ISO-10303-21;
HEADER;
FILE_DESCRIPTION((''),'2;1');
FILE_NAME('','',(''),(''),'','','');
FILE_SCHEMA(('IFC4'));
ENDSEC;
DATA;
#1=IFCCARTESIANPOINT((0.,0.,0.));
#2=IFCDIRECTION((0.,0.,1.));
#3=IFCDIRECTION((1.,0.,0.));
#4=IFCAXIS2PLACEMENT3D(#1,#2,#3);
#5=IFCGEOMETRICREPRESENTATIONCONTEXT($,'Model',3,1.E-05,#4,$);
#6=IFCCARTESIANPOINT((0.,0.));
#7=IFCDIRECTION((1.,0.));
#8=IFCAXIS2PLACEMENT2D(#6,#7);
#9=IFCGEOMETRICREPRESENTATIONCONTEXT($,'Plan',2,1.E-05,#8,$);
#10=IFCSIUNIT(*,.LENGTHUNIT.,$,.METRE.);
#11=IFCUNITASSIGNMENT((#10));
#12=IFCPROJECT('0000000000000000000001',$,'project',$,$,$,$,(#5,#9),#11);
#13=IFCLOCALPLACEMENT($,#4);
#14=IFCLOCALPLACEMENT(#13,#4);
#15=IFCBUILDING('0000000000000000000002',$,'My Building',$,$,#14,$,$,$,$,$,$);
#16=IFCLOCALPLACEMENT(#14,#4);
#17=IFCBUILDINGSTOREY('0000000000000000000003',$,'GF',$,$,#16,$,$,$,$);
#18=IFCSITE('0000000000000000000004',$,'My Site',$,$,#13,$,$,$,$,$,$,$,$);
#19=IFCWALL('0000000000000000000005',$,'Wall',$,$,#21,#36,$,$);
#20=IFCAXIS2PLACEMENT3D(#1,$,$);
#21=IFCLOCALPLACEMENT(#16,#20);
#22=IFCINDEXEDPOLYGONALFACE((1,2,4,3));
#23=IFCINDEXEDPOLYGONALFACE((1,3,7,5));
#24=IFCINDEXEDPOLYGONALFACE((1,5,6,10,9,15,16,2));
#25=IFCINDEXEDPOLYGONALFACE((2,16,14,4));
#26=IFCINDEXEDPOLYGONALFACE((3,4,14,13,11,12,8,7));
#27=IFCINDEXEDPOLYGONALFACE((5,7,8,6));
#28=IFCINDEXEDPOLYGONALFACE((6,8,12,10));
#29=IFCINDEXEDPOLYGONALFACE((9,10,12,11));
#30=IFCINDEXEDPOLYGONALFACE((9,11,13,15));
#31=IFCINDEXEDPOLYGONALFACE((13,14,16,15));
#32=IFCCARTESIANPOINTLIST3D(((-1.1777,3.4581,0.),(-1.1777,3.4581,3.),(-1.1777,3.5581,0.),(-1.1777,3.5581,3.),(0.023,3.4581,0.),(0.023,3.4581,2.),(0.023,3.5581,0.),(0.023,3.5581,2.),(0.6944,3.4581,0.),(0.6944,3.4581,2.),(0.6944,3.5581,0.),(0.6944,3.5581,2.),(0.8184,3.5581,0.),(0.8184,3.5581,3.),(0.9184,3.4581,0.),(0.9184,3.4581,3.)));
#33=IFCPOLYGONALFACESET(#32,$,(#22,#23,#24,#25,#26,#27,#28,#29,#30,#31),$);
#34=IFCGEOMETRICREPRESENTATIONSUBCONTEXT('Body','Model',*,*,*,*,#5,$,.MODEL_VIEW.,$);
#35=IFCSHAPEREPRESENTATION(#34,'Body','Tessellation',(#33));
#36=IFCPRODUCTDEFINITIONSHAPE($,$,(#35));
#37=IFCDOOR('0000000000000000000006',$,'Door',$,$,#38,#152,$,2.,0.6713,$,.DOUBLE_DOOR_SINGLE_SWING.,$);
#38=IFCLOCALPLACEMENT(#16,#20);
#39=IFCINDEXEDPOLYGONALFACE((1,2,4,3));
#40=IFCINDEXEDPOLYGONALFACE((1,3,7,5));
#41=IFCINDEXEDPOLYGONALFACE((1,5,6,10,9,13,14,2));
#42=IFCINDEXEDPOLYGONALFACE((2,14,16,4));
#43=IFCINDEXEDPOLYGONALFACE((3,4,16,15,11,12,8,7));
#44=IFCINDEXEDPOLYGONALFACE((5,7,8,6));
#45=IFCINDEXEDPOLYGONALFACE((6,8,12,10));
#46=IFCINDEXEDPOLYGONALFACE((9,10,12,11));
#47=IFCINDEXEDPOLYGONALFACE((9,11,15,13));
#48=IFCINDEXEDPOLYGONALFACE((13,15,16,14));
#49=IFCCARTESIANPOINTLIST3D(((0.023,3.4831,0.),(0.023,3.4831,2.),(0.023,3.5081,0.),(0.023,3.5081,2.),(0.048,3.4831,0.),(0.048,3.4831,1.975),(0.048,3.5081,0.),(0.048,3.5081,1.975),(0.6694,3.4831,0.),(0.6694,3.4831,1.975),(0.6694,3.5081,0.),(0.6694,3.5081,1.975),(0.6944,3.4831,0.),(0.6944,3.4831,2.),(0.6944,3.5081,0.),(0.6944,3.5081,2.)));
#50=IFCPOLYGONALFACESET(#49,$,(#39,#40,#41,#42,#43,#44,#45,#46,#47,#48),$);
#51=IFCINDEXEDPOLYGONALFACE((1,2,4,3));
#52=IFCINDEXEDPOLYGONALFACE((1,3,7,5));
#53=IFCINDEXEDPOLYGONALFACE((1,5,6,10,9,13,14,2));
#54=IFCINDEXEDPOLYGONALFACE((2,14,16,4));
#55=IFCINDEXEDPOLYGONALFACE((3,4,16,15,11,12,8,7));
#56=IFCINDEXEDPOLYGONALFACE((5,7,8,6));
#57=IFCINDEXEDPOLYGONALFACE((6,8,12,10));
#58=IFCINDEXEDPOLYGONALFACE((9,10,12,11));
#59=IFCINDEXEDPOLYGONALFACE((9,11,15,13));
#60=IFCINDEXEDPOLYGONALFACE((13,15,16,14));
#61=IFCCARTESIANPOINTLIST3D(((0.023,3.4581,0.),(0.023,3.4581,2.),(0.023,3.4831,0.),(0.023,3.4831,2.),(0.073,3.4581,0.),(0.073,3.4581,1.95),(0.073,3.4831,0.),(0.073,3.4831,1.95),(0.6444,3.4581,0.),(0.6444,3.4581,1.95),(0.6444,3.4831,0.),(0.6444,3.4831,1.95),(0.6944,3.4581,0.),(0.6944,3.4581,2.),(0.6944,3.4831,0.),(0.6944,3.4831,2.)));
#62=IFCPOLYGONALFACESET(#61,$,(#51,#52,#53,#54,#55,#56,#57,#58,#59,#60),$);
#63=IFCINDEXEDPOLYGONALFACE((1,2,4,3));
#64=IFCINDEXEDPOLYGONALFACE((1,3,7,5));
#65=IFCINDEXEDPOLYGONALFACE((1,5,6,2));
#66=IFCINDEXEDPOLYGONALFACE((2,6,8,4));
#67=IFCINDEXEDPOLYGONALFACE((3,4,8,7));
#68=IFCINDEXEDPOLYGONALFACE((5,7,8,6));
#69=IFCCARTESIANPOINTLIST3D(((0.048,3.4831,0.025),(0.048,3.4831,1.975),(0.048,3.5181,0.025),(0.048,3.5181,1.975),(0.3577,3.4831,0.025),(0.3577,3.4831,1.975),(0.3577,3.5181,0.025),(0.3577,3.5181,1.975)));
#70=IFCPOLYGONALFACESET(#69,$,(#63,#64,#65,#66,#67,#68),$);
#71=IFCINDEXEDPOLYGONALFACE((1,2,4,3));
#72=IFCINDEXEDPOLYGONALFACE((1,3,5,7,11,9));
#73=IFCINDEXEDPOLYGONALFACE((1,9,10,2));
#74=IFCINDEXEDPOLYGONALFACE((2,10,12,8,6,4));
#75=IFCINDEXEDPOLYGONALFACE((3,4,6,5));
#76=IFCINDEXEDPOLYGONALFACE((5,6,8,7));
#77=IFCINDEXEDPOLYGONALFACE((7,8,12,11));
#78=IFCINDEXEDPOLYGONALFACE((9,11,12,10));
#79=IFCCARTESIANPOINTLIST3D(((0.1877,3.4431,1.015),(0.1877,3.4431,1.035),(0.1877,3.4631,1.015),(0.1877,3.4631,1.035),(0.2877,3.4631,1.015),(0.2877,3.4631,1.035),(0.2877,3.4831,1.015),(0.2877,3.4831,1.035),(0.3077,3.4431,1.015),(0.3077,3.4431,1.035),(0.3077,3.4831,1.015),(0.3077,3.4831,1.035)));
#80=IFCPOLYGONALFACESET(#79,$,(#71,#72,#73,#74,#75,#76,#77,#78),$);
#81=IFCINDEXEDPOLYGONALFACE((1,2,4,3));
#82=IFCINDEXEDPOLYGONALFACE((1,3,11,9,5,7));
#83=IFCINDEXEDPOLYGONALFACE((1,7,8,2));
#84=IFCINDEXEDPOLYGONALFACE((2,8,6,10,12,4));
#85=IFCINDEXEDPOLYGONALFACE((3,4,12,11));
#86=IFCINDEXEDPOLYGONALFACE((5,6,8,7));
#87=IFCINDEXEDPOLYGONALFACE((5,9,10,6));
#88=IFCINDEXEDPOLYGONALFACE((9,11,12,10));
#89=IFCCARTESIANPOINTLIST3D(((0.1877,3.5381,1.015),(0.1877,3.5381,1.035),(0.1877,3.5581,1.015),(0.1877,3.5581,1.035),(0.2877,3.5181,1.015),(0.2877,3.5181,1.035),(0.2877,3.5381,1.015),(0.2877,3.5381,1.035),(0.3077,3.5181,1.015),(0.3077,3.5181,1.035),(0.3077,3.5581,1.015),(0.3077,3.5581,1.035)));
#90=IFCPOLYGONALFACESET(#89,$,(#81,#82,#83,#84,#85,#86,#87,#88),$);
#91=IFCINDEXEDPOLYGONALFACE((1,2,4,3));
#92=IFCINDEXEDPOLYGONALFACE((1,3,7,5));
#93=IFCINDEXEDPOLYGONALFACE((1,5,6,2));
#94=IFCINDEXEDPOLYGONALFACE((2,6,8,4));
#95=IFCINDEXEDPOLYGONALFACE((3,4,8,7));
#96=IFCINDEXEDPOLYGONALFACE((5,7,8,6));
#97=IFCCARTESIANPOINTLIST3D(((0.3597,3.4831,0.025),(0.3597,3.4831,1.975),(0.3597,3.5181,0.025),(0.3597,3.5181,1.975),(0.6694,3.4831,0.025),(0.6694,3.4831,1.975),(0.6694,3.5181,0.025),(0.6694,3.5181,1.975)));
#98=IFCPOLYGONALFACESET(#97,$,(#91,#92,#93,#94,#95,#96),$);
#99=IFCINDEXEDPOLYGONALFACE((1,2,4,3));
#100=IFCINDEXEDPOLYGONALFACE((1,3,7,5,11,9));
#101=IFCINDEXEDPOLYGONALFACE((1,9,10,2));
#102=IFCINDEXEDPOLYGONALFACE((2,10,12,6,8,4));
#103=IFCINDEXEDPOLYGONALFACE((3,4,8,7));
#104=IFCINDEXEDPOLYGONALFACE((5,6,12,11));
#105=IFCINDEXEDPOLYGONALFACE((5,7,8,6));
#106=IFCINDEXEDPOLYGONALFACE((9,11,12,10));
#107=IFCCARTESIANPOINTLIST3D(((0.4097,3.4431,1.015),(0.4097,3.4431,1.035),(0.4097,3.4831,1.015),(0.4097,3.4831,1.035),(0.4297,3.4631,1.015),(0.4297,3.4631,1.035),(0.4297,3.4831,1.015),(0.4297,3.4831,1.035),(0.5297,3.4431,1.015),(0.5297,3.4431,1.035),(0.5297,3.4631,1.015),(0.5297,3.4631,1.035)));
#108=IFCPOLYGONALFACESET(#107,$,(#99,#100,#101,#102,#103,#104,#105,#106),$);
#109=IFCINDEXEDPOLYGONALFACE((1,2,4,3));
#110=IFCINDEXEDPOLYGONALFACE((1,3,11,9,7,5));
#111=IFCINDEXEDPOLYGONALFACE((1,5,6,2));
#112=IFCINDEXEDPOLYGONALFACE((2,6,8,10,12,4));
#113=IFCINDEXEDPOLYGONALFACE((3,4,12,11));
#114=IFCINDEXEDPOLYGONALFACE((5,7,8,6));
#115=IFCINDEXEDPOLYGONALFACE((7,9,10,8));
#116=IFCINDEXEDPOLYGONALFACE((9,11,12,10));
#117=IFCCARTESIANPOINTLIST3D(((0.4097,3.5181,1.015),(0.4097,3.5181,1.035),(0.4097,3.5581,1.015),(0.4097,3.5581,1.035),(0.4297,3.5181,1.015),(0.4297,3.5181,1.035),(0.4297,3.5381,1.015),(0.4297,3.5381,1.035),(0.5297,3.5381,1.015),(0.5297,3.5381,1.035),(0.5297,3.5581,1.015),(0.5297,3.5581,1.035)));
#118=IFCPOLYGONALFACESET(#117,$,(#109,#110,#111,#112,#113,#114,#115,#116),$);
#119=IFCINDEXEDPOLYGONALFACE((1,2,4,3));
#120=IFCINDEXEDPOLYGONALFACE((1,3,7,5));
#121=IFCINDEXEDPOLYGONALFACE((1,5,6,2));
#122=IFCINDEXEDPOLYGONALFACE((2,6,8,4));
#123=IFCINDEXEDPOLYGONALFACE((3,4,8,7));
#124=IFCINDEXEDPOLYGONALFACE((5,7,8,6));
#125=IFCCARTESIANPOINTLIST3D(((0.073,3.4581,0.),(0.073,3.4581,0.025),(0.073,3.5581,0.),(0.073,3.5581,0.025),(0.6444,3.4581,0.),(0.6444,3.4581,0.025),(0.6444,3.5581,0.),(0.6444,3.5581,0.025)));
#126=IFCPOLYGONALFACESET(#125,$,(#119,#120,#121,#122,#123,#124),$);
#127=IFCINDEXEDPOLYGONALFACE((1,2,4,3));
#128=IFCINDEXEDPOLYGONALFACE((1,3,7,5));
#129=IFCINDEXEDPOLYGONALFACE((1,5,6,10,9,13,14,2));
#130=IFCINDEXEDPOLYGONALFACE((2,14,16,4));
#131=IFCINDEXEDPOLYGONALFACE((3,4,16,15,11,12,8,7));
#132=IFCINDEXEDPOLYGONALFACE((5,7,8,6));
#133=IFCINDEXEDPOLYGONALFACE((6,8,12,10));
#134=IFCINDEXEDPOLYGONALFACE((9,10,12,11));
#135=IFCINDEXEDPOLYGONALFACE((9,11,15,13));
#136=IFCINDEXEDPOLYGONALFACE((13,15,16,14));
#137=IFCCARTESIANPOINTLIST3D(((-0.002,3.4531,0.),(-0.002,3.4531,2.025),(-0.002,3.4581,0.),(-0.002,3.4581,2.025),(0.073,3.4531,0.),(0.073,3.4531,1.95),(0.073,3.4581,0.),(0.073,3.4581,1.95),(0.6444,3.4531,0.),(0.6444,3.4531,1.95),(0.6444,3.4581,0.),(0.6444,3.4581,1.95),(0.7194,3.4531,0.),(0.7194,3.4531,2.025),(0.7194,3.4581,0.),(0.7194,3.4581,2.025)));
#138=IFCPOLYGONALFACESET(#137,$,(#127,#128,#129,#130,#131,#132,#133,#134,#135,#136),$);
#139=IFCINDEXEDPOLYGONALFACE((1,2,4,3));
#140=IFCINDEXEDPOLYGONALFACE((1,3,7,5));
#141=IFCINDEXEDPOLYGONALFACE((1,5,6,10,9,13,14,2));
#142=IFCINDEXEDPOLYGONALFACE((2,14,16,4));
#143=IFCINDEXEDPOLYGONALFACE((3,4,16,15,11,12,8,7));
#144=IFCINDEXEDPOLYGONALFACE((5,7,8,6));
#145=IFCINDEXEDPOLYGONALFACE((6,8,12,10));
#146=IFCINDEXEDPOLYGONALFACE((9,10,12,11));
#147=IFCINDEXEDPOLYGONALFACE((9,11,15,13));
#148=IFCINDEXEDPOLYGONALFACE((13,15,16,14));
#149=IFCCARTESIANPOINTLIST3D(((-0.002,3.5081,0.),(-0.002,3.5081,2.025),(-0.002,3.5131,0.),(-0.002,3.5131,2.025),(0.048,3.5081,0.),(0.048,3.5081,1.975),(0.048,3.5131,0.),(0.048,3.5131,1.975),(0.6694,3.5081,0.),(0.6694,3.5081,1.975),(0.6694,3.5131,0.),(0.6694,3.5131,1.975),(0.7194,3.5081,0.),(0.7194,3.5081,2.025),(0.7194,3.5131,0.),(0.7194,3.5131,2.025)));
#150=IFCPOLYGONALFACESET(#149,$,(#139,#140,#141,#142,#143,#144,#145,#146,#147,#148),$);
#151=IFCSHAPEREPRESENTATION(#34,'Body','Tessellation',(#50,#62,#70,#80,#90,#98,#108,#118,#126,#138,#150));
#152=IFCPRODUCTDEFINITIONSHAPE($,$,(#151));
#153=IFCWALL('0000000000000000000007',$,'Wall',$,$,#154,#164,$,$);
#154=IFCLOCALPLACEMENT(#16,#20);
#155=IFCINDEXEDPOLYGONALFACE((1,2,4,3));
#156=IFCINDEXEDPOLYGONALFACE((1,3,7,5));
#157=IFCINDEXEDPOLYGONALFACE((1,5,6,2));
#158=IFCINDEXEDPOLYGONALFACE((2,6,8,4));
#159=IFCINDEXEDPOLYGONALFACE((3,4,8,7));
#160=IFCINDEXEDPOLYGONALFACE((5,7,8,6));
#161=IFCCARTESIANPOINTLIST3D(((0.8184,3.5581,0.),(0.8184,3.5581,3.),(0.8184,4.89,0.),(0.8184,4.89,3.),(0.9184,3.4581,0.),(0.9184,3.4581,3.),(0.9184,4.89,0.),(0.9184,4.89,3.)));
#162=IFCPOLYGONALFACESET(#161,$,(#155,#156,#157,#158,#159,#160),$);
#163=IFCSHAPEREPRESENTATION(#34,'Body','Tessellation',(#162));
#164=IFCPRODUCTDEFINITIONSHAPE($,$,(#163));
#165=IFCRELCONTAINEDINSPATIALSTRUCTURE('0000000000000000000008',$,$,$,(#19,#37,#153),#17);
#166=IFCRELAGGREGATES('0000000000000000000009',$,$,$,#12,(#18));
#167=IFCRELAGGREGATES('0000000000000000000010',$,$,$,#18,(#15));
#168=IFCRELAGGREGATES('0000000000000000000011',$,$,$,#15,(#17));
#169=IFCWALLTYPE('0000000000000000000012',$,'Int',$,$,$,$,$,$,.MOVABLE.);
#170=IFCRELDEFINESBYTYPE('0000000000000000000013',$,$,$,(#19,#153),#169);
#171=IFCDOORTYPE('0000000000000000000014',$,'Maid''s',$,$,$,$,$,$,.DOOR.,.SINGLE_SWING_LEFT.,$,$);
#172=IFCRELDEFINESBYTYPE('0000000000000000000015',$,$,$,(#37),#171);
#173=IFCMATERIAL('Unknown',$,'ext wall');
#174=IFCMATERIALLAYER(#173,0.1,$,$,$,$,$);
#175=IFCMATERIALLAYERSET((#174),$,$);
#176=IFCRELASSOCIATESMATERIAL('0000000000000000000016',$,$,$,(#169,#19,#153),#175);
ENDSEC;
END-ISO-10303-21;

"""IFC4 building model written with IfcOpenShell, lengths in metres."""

from ifc_helpers import new_model, entity, si_unit, frame, origin_with_axes, origin_2d_with_axis, place, context, subcontext, project, spatial, line, indexed_curve, outline, extrude, shape, source, transform, mapped, material, layer, layer_set, layer_usage, type_object, type_shapes, element, fill, save


model = new_model("IFC4")

# Units and contexts
model_context = context("Model", 3, precision=1e-05, world=origin_with_axes())
plan_context = context("Plan", 2, precision=1e-05, world=origin_2d_with_axis())
body_context_1 = subcontext(model_context, "Body", "Model", "MODEL_VIEW")
body_context_2 = subcontext(plan_context, "Body", "Plan", "PLAN_VIEW")
ifc_project = project(units=[si_unit("LENGTHUNIT", "METRE")], contexts=[model_context, plan_context])

# Site, building, storey
site_placement = place(None, origin_with_axes())
site = spatial("IfcSite", under=ifc_project, at=site_placement, Name="My Site")
building_placement = place(site_placement, origin_with_axes())
building = spatial("IfcBuilding", under=site, at=building_placement, Name="My Building")
storey_placement = place(building_placement, origin_with_axes())
storey = spatial("IfcBuildingStorey", under=building, at=storey_placement, Name="GF")

# Shared definitions
ifc_material = material(Name="Unknown", Category="ext wall")

# Wall, opening, door
ifc_layer_1 = layer(ifc_material, 0.1)
ifc_layer_set_1 = layer_set([ifc_layer_1])
wall_type_1 = type_object("IfcWallType", Name="Int", PredefinedType="MOVABLE", material=ifc_layer_set_1)
ifc_layer_usage_1 = layer_usage(ifc_layer_set_1, "AXIS2", "POSITIVE", 0.0)
wall_1_placement = place(storey_placement, frame((-1.1777, 3.4581, 0.0), z_axis=(0.0, 0.0, 1.0), x_axis=(1.0, 0.0, 0.0)))
wall_1 = element("IfcWall", 1, at=wall_1_placement, inside=storey, type_object=wall_type_1, material=ifc_layer_usage_1, Name="Wall", context=body_context_1, shape_type="SweptSolid", body=[
    extrude(outline(indexed_curve([(0.0, 0.0), (0.0, 0.1), (1.9961, 0.1), (2.0961, 0.0)], segments=[line(1, 2, 3, 4, 1)])), origin_with_axes(), (0.0, 0.0, 1.0), 3.0),
])
shared_shape_1 = source(origin_with_axes(), body_context_1, "Body", "SweptSolid", [
    extrude(outline(indexed_curve([(0.0, 0.0), (0.6713, 0.0), (0.6713, 2.0), (0.0, 2.0)], segments=[line(1, 2, 3, 4, 1)])), frame((0.0, -0.6, 0.0), z_axis=(0.0, -1.0, 0.0), x_axis=(1.0, 0.0, 0.0)), (0.0, 0.0, -1.0), 1.2),
])
opening_1_placement = place(wall_1_placement, frame((1.2007, 0.0, 0.0), z_axis=(0.0, 0.0, 1.0), x_axis=(1.0, 0.0, 0.0)))
opening_1 = element("IfcOpeningElement", 2, at=opening_1_placement, cuts=wall_1, PredefinedType="OPENING", context=body_context_1, shape_type="MappedRepresentation", body=[
    mapped(shared_shape_1, transform((0.0, 0.0, 0.0), x_axis=(1.0, 0.0, 0.0), y_axis=(0.0, 1.0, 0.0), z_axis=(0.0, 0.0, 1.0), scale=1.0)),
])
door_type_1 = type_object("IfcDoorType", Name="Maid's", OperationType="SINGLE_SWING_LEFT", PredefinedType="DOOR")
shared_shape_2 = source(origin_with_axes(), body_context_1, "Body", "SweptSolid", [
    extrude(outline(indexed_curve([(0.0, 0.0), (0.0, 2.0), (0.6713, 2.0), (0.6713, 0.0), (0.6463, 0.0), (0.6463, 1.975), (0.025, 1.975), (0.025, 0.0)], segments=[line(1, 2, 3, 4, 5, 6, 7, 8, 1)])), frame((0.0, 0.025, 0.0), z_axis=(0.0, -1.0, 0.0), x_axis=(1.0, 0.0, 0.0)), (0.0, 0.0, -1.0), 0.025),
    extrude(outline(indexed_curve([(0.0, 0.0), (0.0, 2.0), (0.6713, 2.0), (0.6713, 0.0), (0.6213, 0.0), (0.6213, 1.95), (0.05, 1.95), (0.05, 0.0)], segments=[line(1, 2, 3, 4, 5, 6, 7, 8, 1)])), frame((0.0, 0.0, 0.0), z_axis=(0.0, -1.0, 0.0), x_axis=(1.0, 0.0, 0.0)), (0.0, 0.0, -1.0), 0.025),
    extrude(outline(indexed_curve([(0.0, 0.0), (0.3097, 0.0), (0.3097, 0.035), (0.0, 0.035)], segments=[line(1, 2, 3, 4, 1)])), frame((0.025, 0.025, 0.025), z_axis=(0.0, 0.0, 1.0), x_axis=(1.0, 0.0, 0.0)), (0.0, 0.0, 1.0), 1.95),
    extrude(outline(indexed_curve([(0.0, 0.0), (0.0, -0.04), (-0.12, -0.04), (-0.12, -0.02), (-0.02, -0.02), (-0.02, 0.0)], segments=[line(1, 2, 3, 4, 5, 6, 1)])), frame((0.2847, 0.025, 1.015), z_axis=(0.0, 0.0, 1.0), x_axis=(1.0, 0.0, 0.0)), (0.0, 0.0, 1.0), 0.02),
    extrude(outline(indexed_curve([(0.0, 0.0), (0.0, 0.04), (-0.12, 0.04), (-0.12, 0.02), (-0.02, 0.02), (-0.02, 0.0)], segments=[line(1, 2, 3, 4, 5, 6, 1)])), frame((0.2847, 0.06, 1.015), z_axis=(0.0, 0.0, 1.0), x_axis=(1.0, 0.0, 0.0)), (0.0, 0.0, 1.0), 0.02),
    extrude(outline(indexed_curve([(0.0, 0.0), (-0.3097, 0.0), (-0.3097, 0.035), (0.0, 0.035)], segments=[line(1, 2, 3, 4, 1)])), frame((0.6463, 0.025, 0.025), z_axis=(0.0, 0.0, 1.0), x_axis=(1.0, 0.0, 0.0)), (0.0, 0.0, 1.0), 1.95),
    extrude(outline(indexed_curve([(0.0, 0.0), (0.0, -0.04), (0.12, -0.04), (0.12, -0.02), (0.02, -0.02), (0.02, 0.0)], segments=[line(1, 2, 3, 4, 5, 6, 1)])), frame((0.3867, 0.025, 1.015), z_axis=(0.0, 0.0, 1.0), x_axis=(1.0, 0.0, 0.0)), (0.0, 0.0, 1.0), 0.02),
    extrude(outline(indexed_curve([(0.0, 0.0), (0.0, 0.04), (0.12, 0.04), (0.12, 0.02), (0.02, 0.02), (0.02, 0.0)], segments=[line(1, 2, 3, 4, 5, 6, 1)])), frame((0.3867, 0.06, 1.015), z_axis=(0.0, 0.0, 1.0), x_axis=(1.0, 0.0, 0.0)), (0.0, 0.0, 1.0), 0.02),
    extrude(outline(indexed_curve([(0.0, 0.0), (0.5713, 0.0), (0.5713, 0.1), (0.0, 0.1)], segments=[line(1, 2, 3, 4, 1)])), frame((0.05, 0.0, 0.0), z_axis=(0.0, 0.0, 1.0), x_axis=(1.0, 0.0, 0.0)), (0.0, 0.0, 1.0), 0.025),
    extrude(outline(indexed_curve([(0.0, 0.0), (0.0, 2.025), (0.7213, 2.025), (0.7213, 0.0), (0.6463, 0.0), (0.6463, 1.95), (0.075, 1.95), (0.075, 0.0)], segments=[line(1, 2, 3, 4, 5, 6, 7, 8, 1)])), frame((-0.025, -0.005, 0.0), z_axis=(0.0, -1.0, 0.0), x_axis=(1.0, 0.0, 0.0)), (0.0, 0.0, -1.0), 0.005),
    extrude(outline(indexed_curve([(0.0, 0.0), (0.0, 2.025), (0.7213, 2.025), (0.7213, 0.0), (0.6713, 0.0), (0.6713, 1.975), (0.05, 1.975), (0.05, 0.0)], segments=[line(1, 2, 3, 4, 5, 6, 7, 8, 1)])), frame((-0.025, 0.05, 0.0), z_axis=(0.0, -1.0, 0.0), x_axis=(1.0, 0.0, 0.0)), (0.0, 0.0, -1.0), 0.005),
])
shared_shape_3 = source(origin_with_axes(), body_context_2, "Body", "Curve2D", [
    entity("IfcIndexedPolyCurve", entity("IfcCartesianPointList2D", [[0.0, 0.0], [0.0, 0.05], [0.025, 0.05], [0.025, 0.025], [0.05, 0.025], [0.05, 0.0]]), [entity("IfcLineIndex", [1, 2, 3, 4, 5, 6, 1])]),
    entity("IfcIndexedPolyCurve", entity("IfcCartesianPointList2D", [[0.6713, 0.0], [0.6713, 0.05], [0.6463, 0.05], [0.6463, 0.025], [0.6213, 0.025], [0.6213, 0.0]]), [entity("IfcLineIndex", [1, 2, 3, 4, 5, 6, 1])]),
    entity("IfcTrimmedCurve", entity("IfcEllipse", entity("IfcAxis2Placement2D", entity("IfcCartesianPoint", [0.06, 0.05]), entity("IfcDirection", [1.0, 0.0])), 0.2757, 0.3107), [entity("IfcCartesianPoint", [0.3357, 0.05])], [entity("IfcCartesianPoint", [0.06, 0.3607])], True, "CARTESIAN"),
    entity("IfcIndexedPolyCurve", entity("IfcCartesianPointList2D", [[0.025, 0.05], [0.06, 0.05], [0.06, 0.3607], [0.025, 0.3607]]), [entity("IfcLineIndex", [1, 2, 3, 4, 1])]),
    entity("IfcTrimmedCurve", entity("IfcEllipse", entity("IfcAxis2Placement2D", entity("IfcCartesianPoint", [0.6113, 0.05]), entity("IfcDirection", [1.0, 0.0])), 0.2757, 0.3107), [entity("IfcCartesianPoint", [0.6113, 0.3607])], [entity("IfcCartesianPoint", [0.3357, 0.05])], True, "CARTESIAN"),
    entity("IfcIndexedPolyCurve", entity("IfcCartesianPointList2D", [[0.6463, 0.05], [0.6113, 0.05], [0.6113, 0.3607], [0.6463, 0.3607]]), [entity("IfcLineIndex", [1, 2, 3, 4, 1])]),
])
type_shapes(door_type_1, [shared_shape_2, shared_shape_3])
door_1_placement = place(opening_1_placement, origin_with_axes())
door_1 = element("IfcDoor", 3, at=door_1_placement, inside=storey, type_object=door_type_1, Name="Door", OperationType="DOUBLE_DOOR_SINGLE_SWING", OverallHeight=2.0, OverallWidth=0.6713, shapes=[
    shape(body_context_1, "Body", "MappedRepresentation", [mapped(shared_shape_2, transform((0.0, 0.0, 0.0), x_axis=(1.0, 0.0, 0.0), y_axis=(0.0, 1.0, 0.0), z_axis=(0.0, 0.0, 1.0), scale=1.0))]),
    shape(body_context_2, "Body", "MappedRepresentation", [mapped(shared_shape_3, transform((0.0, 0.0, 0.0), x_axis=(1.0, 0.0, 0.0), y_axis=(0.0, 1.0, 0.0), z_axis=(0.0, 0.0, 1.0), scale=1.0))]),
])
fill(opening_1, door_1)

# Wall
ifc_layer_usage_2 = layer_usage(ifc_layer_set_1, "AXIS2", "POSITIVE", 0.0)
wall_2_placement = place(storey_placement, frame((0.9184, 3.4581, 0.0), z_axis=(0.0, 0.0, 1.0), x_axis=(0.0, 1.0, 0.0)))
element("IfcWall", 4, at=wall_2_placement, inside=storey, type_object=wall_type_1, material=ifc_layer_usage_2, Name="Wall", context=body_context_1, shape_type="SweptSolid", body=[
    extrude(outline(indexed_curve([(0.0, 0.0), (0.1, 0.1), (1.4319, 0.1), (1.4319, 0.0)], segments=[line(1, 2, 3, 4, 1)])), origin_with_axes(), (0.0, 0.0, 1.0), 3.0),
])

save(model, "model.ifc")
